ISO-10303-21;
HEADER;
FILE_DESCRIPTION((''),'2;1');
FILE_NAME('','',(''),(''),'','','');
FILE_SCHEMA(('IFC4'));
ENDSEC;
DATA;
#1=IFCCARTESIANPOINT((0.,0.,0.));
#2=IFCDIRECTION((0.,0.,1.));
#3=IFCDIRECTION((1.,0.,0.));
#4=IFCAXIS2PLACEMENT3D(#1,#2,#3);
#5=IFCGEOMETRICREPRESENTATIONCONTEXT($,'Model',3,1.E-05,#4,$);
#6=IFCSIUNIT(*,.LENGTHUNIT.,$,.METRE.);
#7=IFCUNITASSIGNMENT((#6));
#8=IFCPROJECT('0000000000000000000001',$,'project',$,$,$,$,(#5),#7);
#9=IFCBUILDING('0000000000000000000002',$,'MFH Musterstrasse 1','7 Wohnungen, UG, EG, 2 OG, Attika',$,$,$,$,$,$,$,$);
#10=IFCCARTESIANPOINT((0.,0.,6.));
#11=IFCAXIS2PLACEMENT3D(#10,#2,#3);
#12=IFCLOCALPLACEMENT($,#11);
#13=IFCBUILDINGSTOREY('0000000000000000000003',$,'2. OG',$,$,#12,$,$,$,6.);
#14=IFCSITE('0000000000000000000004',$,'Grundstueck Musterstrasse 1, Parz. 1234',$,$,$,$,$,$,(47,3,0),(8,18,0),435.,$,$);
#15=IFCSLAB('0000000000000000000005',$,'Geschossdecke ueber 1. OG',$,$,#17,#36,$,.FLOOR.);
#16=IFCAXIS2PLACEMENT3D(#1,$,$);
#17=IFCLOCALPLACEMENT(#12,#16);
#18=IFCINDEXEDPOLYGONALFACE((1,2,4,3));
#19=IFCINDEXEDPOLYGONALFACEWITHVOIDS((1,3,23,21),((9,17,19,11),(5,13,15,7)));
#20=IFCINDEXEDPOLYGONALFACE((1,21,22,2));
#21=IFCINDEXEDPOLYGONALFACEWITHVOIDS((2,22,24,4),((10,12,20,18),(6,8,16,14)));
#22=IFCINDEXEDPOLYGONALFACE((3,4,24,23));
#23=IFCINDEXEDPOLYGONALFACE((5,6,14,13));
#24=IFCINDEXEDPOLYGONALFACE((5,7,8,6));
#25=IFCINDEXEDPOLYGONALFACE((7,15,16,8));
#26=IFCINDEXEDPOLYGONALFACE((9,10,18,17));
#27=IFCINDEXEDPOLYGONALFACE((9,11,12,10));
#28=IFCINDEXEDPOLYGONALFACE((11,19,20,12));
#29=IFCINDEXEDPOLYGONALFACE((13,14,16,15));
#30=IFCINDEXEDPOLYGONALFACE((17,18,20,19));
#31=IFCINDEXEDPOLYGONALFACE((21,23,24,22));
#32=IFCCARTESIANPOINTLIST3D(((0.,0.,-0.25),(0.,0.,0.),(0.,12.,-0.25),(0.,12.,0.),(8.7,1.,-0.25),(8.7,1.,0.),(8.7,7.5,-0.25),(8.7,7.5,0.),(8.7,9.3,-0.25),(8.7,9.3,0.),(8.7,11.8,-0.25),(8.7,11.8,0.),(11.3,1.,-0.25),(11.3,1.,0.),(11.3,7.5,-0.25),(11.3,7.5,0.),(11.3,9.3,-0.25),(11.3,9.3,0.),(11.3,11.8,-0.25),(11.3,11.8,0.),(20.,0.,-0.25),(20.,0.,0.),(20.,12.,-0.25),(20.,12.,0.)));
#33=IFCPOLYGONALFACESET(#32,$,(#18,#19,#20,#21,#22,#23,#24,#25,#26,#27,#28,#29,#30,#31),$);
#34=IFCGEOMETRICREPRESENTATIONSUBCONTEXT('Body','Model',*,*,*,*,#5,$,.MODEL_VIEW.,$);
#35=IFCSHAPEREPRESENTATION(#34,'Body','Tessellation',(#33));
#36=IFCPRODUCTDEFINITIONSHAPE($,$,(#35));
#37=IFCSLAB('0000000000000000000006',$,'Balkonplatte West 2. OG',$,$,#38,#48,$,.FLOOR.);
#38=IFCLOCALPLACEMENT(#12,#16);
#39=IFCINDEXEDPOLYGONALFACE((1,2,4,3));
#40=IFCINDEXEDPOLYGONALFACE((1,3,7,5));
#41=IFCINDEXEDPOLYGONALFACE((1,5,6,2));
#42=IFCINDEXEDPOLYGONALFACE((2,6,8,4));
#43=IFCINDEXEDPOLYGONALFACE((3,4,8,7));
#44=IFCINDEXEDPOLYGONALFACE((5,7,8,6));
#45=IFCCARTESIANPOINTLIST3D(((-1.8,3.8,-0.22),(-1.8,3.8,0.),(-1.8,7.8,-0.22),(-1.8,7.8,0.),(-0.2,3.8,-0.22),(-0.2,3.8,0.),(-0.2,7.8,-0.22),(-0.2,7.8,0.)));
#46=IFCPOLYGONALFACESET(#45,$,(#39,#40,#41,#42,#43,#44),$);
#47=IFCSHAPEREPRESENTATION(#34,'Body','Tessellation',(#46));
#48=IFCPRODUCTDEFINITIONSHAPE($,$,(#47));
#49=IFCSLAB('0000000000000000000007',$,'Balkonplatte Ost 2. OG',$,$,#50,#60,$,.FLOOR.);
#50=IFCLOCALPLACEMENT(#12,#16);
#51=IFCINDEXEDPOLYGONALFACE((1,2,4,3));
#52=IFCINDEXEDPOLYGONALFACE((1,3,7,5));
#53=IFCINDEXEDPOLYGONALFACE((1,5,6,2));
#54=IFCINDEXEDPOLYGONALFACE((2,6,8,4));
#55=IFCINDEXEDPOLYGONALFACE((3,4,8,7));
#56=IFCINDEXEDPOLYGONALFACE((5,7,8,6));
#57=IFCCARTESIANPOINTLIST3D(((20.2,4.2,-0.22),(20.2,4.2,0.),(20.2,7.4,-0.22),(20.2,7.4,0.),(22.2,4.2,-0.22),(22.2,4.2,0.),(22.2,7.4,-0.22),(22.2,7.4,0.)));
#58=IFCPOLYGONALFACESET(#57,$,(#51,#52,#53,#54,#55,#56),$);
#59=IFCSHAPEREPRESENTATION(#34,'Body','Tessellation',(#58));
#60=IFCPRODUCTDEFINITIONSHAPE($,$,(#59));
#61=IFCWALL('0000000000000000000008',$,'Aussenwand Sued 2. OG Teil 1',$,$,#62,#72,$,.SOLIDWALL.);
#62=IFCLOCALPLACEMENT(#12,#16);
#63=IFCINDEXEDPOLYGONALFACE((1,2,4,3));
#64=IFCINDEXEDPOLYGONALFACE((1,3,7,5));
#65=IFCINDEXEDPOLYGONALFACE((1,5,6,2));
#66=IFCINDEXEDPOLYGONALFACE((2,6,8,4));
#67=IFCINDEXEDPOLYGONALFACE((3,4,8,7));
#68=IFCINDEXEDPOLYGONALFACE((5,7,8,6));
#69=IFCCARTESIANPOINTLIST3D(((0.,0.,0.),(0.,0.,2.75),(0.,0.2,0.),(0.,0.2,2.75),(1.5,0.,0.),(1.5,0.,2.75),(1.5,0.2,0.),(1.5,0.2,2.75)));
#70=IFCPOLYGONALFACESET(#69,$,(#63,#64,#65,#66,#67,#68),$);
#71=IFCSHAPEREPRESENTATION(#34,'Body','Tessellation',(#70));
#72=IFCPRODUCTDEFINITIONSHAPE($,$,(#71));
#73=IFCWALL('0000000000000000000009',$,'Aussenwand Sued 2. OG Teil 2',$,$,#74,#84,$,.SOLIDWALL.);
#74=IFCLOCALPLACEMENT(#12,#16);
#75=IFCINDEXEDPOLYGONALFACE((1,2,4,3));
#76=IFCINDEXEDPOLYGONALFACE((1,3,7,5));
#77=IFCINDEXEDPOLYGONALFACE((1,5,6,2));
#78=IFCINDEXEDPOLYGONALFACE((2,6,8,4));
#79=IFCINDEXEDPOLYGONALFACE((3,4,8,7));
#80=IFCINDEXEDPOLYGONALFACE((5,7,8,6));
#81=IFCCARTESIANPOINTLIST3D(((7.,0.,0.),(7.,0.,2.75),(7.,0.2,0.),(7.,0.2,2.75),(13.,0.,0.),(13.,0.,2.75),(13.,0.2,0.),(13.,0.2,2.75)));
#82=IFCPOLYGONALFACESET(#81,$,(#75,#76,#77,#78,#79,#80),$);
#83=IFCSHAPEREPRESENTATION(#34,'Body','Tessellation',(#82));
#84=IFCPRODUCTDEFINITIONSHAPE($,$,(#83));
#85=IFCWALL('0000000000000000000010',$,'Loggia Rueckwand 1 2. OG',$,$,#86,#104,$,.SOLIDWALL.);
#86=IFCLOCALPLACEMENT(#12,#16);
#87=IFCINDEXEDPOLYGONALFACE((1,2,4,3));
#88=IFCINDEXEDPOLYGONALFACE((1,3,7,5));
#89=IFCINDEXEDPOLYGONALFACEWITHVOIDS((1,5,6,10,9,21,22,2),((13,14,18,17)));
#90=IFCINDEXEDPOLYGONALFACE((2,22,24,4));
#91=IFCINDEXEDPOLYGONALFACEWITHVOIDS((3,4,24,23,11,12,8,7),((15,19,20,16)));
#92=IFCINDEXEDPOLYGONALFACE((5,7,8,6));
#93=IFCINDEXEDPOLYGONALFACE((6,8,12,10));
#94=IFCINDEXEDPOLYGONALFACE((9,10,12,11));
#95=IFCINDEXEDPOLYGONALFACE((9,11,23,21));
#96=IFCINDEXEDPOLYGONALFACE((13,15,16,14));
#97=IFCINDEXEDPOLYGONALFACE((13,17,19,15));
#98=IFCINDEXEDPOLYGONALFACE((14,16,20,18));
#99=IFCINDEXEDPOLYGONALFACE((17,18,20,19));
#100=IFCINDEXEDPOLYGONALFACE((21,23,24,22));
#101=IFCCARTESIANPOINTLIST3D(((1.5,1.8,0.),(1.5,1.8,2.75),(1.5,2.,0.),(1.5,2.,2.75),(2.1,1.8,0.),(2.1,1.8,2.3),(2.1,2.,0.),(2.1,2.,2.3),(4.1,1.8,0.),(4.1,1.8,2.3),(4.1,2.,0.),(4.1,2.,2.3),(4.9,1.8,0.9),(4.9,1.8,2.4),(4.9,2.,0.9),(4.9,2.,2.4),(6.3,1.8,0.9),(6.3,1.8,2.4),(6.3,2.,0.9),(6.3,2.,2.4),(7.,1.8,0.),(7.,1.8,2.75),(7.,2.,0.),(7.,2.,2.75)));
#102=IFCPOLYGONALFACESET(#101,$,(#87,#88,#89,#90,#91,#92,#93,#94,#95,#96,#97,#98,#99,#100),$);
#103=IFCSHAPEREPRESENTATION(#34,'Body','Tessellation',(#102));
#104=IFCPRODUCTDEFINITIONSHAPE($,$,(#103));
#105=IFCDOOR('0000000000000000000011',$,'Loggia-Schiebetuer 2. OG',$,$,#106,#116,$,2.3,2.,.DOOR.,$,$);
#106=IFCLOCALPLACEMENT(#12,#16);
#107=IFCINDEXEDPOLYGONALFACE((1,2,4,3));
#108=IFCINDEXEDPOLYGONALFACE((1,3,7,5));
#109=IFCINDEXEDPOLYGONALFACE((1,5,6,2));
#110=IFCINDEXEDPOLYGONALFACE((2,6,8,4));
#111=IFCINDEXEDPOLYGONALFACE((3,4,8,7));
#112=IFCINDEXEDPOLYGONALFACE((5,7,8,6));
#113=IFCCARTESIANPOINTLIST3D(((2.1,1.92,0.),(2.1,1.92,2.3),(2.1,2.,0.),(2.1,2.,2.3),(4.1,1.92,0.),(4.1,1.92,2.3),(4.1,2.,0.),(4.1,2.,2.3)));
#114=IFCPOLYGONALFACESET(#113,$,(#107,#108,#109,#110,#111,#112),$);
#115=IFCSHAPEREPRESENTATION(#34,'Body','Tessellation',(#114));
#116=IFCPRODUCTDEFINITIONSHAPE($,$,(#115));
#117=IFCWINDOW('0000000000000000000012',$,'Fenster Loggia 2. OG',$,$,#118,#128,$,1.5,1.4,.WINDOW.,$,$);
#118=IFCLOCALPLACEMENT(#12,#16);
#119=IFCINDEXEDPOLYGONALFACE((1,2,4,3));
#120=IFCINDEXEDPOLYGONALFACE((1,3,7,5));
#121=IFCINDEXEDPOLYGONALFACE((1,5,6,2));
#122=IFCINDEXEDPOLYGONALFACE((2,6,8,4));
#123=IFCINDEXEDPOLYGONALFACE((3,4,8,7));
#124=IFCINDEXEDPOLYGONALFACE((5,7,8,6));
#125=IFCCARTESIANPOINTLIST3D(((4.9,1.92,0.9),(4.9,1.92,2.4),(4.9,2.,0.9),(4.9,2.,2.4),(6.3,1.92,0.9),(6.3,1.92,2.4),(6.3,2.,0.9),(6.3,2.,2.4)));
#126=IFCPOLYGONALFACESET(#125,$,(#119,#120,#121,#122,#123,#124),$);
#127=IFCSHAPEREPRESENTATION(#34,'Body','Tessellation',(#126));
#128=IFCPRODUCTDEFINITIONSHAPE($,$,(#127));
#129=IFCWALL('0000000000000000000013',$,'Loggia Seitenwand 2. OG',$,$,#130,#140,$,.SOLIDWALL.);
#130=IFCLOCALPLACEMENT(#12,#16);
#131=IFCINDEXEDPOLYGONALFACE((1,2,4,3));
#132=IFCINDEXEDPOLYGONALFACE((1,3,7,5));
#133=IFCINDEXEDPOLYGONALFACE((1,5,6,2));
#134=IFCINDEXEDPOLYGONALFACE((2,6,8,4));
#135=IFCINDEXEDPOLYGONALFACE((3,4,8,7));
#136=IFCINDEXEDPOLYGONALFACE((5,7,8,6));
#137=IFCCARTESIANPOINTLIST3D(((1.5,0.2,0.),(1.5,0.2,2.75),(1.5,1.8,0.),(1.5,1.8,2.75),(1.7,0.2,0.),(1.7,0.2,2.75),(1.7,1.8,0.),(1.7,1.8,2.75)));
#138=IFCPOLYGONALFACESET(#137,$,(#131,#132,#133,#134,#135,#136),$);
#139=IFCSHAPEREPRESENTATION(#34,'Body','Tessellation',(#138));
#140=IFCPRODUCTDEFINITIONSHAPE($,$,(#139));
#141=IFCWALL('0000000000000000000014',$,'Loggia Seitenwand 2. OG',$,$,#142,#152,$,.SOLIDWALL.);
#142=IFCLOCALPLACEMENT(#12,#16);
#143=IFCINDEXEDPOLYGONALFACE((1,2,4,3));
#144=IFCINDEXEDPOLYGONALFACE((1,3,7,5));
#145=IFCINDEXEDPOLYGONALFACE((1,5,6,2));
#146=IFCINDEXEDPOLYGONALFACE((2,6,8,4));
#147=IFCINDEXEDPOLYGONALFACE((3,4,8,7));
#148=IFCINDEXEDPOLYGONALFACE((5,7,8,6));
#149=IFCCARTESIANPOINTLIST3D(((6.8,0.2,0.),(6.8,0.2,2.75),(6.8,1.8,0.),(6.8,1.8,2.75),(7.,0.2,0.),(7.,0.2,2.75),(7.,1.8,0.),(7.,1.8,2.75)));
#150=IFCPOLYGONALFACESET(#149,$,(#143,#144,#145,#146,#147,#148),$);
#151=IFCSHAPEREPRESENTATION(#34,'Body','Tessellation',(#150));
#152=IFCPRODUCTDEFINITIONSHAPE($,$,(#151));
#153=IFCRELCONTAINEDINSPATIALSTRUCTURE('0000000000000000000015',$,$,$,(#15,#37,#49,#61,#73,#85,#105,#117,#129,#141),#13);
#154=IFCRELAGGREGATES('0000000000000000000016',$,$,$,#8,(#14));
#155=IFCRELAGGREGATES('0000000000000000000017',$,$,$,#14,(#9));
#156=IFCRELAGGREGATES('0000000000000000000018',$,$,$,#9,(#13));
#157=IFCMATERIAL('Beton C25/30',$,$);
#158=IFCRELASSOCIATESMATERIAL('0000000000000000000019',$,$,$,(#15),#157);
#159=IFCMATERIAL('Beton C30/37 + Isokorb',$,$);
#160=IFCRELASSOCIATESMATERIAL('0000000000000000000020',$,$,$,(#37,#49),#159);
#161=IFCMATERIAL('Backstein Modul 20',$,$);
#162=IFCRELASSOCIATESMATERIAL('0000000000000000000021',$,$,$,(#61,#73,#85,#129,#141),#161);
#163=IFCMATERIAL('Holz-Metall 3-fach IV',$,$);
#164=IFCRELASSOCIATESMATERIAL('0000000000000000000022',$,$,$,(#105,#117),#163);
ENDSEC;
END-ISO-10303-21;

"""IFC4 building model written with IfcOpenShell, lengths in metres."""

from ifc_helpers import new_model, si_unit, frame, frame_2d, origin_with_axes, place, context, subcontext, project, spatial, polyline, rectangle, outline, extrude, material, element, fill, save


model = new_model("IFC4")

# Units and contexts
model_context = context("Model", 3, precision=1e-05, world=origin_with_axes())
body_context = subcontext(model_context, "Body", "Model", "MODEL_VIEW")
ifc_project = project(units=[si_unit("LENGTHUNIT", "METRE")], contexts=[model_context])

# Site, building, storey
site = spatial("IfcSite", under=ifc_project, Name="Grundstueck Musterstrasse 1, Parz. 1234", RefLatitude=(47, 3, 0), RefLongitude=(8, 18, 0), RefElevation=435.0)
building = spatial("IfcBuilding", under=site, Name="MFH Musterstrasse 1", Description="7 Wohnungen, UG, EG, 2 OG, Attika")
storey_placement = place(None, frame((0.0, 0.0, 6.0), z_axis=(0.0, 0.0, 1.0), x_axis=(1.0, 0.0, 0.0)))
storey = spatial("IfcBuildingStorey", under=building, at=storey_placement, Name="2. OG", Elevation=6.0)

# Slab, openings
ifc_material_1 = material(Name="Beton C25/30")
slab_1_placement = place(storey_placement, frame((0.0, 0.0, -0.25), z_axis=(0.0, 0.0, 1.0), x_axis=(1.0, 0.0, 0.0)))
slab_1 = element("IfcSlab", 1, at=slab_1_placement, inside=storey, material=ifc_material_1, Name="Geschossdecke ueber 1. OG", PredefinedType="FLOOR", context=body_context, shape_type="SweptSolid", body=[
    extrude(outline(polyline([(0.0, 0.0), (20.0, 0.0), (20.0, 12.0), (0.0, 12.0), (0.0, 0.0)])), origin_with_axes(), (0.0, 0.0, 1.0), 0.25),
])
opening_1_placement = place(slab_1_placement, frame((8.7, 1.0, -0.01), z_axis=(0.0, 0.0, 1.0), x_axis=(1.0, 0.0, 0.0)))
element("IfcOpeningElement", 2, at=opening_1_placement, cuts=slab_1, context=body_context, shape_type="SweptSolid", body=[
    extrude(rectangle(XDim=2.6, YDim=6.5, at=frame_2d((1.3, 3.25))), origin_with_axes(), (0.0, 0.0, 1.0), 0.27),
])
opening_2_placement = place(slab_1_placement, frame((8.7, 9.3, -0.01), z_axis=(0.0, 0.0, 1.0), x_axis=(1.0, 0.0, 0.0)))
element("IfcOpeningElement", 3, at=opening_2_placement, cuts=slab_1, context=body_context, shape_type="SweptSolid", body=[
    extrude(rectangle(XDim=2.6, YDim=2.5, at=frame_2d((1.3, 1.25))), origin_with_axes(), (0.0, 0.0, 1.0), 0.27),
])

# Slabs
ifc_material_2 = material(Name="Beton C30/37 + Isokorb")
slab_2_placement = place(storey_placement, frame((0.0, 0.0, -0.22), z_axis=(0.0, 0.0, 1.0), x_axis=(1.0, 0.0, 0.0)))
element("IfcSlab", 4, at=slab_2_placement, inside=storey, material=ifc_material_2, Name="Balkonplatte West 2. OG", PredefinedType="FLOOR", context=body_context, shape_type="SweptSolid", body=[
    extrude(outline(polyline([(-1.8, 3.8), (-0.2, 3.8), (-0.2, 7.8), (-1.8, 7.8), (-1.8, 3.8)])), origin_with_axes(), (0.0, 0.0, 1.0), 0.22),
])
slab_3_placement = place(storey_placement, frame((0.0, 0.0, -0.22), z_axis=(0.0, 0.0, 1.0), x_axis=(1.0, 0.0, 0.0)))
element("IfcSlab", 5, at=slab_3_placement, inside=storey, material=ifc_material_2, Name="Balkonplatte Ost 2. OG", PredefinedType="FLOOR", context=body_context, shape_type="SweptSolid", body=[
    extrude(outline(polyline([(20.2, 4.2), (22.2, 4.2), (22.2, 7.4), (20.2, 7.4), (20.2, 4.2)])), origin_with_axes(), (0.0, 0.0, 1.0), 0.22),
])

# Walls
ifc_material_3 = material(Name="Backstein Modul 20")
wall_1_placement = place(storey_placement, origin_with_axes())
element("IfcWall", 6, at=wall_1_placement, inside=storey, material=ifc_material_3, Name="Aussenwand Sued 2. OG Teil 1", PredefinedType="SOLIDWALL", context=body_context, shape_type="SweptSolid", body=[
    extrude(rectangle(XDim=1.5, YDim=0.2, at=frame_2d((0.75, 0.1))), origin_with_axes(), (0.0, 0.0, 1.0), 2.75),
])
wall_2_placement = place(storey_placement, frame((7.0, 0.0, 0.0), z_axis=(0.0, 0.0, 1.0), x_axis=(1.0, 0.0, 0.0)))
element("IfcWall", 7, at=wall_2_placement, inside=storey, material=ifc_material_3, Name="Aussenwand Sued 2. OG Teil 2", PredefinedType="SOLIDWALL", context=body_context, shape_type="SweptSolid", body=[
    extrude(rectangle(XDim=6.0, YDim=0.2, at=frame_2d((3.0, 0.1))), origin_with_axes(), (0.0, 0.0, 1.0), 2.75),
])

# Wall, openings, door, window
wall_3_placement = place(storey_placement, frame((1.5, 1.8, 0.0), z_axis=(0.0, 0.0, 1.0), x_axis=(1.0, 0.0, 0.0)))
wall_3 = element("IfcWall", 8, at=wall_3_placement, inside=storey, material=ifc_material_3, Name="Loggia Rueckwand 1 2. OG", PredefinedType="SOLIDWALL", context=body_context, shape_type="SweptSolid", body=[
    extrude(rectangle(XDim=5.5, YDim=0.2, at=frame_2d((2.75, 0.1))), origin_with_axes(), (0.0, 0.0, 1.0), 2.75),
])
opening_3_placement = place(wall_3_placement, frame((0.6, -0.21, 0.0), z_axis=(0.0, 0.0, 1.0), x_axis=(1.0, 0.0, 0.0)))
opening_3 = element("IfcOpeningElement", 9, at=opening_3_placement, cuts=wall_3, context=body_context, shape_type="SweptSolid", body=[
    extrude(rectangle(XDim=2.0, YDim=0.42, at=frame_2d((1.0, 0.21))), origin_with_axes(), (0.0, 0.0, 1.0), 2.3),
])
opening_4_placement = place(wall_3_placement, frame((3.4, -0.21, 0.9), z_axis=(0.0, 0.0, 1.0), x_axis=(1.0, 0.0, 0.0)))
opening_4 = element("IfcOpeningElement", 10, at=opening_4_placement, cuts=wall_3, context=body_context, shape_type="SweptSolid", body=[
    extrude(rectangle(XDim=1.4, YDim=0.42, at=frame_2d((0.7, 0.21))), origin_with_axes(), (0.0, 0.0, 1.0), 1.5),
])
ifc_material_4 = material(Name="Holz-Metall 3-fach IV")
door_1_placement = place(storey_placement, frame((2.1, 1.92, 0.0), z_axis=(0.0, 0.0, 1.0), x_axis=(1.0, 0.0, 0.0)))
door_1 = element("IfcDoor", 11, at=door_1_placement, inside=storey, material=ifc_material_4, Name="Loggia-Schiebetuer 2. OG", OverallHeight=2.3, OverallWidth=2.0, PredefinedType="DOOR", context=body_context, shape_type="SweptSolid", body=[
    extrude(rectangle(XDim=2.0, YDim=0.08, at=frame_2d((1.0, 0.04))), origin_with_axes(), (0.0, 0.0, 1.0), 2.3),
])
fill(opening_3, door_1)
window_1_placement = place(storey_placement, frame((4.9, 1.92, 0.9), z_axis=(0.0, 0.0, 1.0), x_axis=(1.0, 0.0, 0.0)))
window_1 = element("IfcWindow", 12, at=window_1_placement, inside=storey, material=ifc_material_4, Name="Fenster Loggia 2. OG", OverallHeight=1.5, OverallWidth=1.4, PredefinedType="WINDOW", context=body_context, shape_type="SweptSolid", body=[
    extrude(rectangle(XDim=1.4, YDim=0.08, at=frame_2d((0.7, 0.04))), origin_with_axes(), (0.0, 0.0, 1.0), 1.5),
])
fill(opening_4, window_1)

# Walls
for number, where, z_axis, x_axis, name in (
    (13, (1.5, 0.2, 0.0), (0.0, 0.0, 1.0), (1.0, 0.0, 0.0), "Loggia Seitenwand 2. OG"),
    (14, (6.8, 0.2, 0.0), (0.0, 0.0, 1.0), (1.0, 0.0, 0.0), "Loggia Seitenwand 2. OG"),
):
    element("IfcWall", number, at=place(storey_placement, frame(where, z_axis=z_axis, x_axis=x_axis)), inside=storey, material=ifc_material_3, Name=name, PredefinedType="SOLIDWALL", context=body_context, shape_type="SweptSolid", body=[
        extrude(rectangle(XDim=0.2, YDim=1.6, at=frame_2d((0.1, 0.8))), origin_with_axes(), (0.0, 0.0, 1.0), 2.75),
    ])

save(model, "model.ifc")
